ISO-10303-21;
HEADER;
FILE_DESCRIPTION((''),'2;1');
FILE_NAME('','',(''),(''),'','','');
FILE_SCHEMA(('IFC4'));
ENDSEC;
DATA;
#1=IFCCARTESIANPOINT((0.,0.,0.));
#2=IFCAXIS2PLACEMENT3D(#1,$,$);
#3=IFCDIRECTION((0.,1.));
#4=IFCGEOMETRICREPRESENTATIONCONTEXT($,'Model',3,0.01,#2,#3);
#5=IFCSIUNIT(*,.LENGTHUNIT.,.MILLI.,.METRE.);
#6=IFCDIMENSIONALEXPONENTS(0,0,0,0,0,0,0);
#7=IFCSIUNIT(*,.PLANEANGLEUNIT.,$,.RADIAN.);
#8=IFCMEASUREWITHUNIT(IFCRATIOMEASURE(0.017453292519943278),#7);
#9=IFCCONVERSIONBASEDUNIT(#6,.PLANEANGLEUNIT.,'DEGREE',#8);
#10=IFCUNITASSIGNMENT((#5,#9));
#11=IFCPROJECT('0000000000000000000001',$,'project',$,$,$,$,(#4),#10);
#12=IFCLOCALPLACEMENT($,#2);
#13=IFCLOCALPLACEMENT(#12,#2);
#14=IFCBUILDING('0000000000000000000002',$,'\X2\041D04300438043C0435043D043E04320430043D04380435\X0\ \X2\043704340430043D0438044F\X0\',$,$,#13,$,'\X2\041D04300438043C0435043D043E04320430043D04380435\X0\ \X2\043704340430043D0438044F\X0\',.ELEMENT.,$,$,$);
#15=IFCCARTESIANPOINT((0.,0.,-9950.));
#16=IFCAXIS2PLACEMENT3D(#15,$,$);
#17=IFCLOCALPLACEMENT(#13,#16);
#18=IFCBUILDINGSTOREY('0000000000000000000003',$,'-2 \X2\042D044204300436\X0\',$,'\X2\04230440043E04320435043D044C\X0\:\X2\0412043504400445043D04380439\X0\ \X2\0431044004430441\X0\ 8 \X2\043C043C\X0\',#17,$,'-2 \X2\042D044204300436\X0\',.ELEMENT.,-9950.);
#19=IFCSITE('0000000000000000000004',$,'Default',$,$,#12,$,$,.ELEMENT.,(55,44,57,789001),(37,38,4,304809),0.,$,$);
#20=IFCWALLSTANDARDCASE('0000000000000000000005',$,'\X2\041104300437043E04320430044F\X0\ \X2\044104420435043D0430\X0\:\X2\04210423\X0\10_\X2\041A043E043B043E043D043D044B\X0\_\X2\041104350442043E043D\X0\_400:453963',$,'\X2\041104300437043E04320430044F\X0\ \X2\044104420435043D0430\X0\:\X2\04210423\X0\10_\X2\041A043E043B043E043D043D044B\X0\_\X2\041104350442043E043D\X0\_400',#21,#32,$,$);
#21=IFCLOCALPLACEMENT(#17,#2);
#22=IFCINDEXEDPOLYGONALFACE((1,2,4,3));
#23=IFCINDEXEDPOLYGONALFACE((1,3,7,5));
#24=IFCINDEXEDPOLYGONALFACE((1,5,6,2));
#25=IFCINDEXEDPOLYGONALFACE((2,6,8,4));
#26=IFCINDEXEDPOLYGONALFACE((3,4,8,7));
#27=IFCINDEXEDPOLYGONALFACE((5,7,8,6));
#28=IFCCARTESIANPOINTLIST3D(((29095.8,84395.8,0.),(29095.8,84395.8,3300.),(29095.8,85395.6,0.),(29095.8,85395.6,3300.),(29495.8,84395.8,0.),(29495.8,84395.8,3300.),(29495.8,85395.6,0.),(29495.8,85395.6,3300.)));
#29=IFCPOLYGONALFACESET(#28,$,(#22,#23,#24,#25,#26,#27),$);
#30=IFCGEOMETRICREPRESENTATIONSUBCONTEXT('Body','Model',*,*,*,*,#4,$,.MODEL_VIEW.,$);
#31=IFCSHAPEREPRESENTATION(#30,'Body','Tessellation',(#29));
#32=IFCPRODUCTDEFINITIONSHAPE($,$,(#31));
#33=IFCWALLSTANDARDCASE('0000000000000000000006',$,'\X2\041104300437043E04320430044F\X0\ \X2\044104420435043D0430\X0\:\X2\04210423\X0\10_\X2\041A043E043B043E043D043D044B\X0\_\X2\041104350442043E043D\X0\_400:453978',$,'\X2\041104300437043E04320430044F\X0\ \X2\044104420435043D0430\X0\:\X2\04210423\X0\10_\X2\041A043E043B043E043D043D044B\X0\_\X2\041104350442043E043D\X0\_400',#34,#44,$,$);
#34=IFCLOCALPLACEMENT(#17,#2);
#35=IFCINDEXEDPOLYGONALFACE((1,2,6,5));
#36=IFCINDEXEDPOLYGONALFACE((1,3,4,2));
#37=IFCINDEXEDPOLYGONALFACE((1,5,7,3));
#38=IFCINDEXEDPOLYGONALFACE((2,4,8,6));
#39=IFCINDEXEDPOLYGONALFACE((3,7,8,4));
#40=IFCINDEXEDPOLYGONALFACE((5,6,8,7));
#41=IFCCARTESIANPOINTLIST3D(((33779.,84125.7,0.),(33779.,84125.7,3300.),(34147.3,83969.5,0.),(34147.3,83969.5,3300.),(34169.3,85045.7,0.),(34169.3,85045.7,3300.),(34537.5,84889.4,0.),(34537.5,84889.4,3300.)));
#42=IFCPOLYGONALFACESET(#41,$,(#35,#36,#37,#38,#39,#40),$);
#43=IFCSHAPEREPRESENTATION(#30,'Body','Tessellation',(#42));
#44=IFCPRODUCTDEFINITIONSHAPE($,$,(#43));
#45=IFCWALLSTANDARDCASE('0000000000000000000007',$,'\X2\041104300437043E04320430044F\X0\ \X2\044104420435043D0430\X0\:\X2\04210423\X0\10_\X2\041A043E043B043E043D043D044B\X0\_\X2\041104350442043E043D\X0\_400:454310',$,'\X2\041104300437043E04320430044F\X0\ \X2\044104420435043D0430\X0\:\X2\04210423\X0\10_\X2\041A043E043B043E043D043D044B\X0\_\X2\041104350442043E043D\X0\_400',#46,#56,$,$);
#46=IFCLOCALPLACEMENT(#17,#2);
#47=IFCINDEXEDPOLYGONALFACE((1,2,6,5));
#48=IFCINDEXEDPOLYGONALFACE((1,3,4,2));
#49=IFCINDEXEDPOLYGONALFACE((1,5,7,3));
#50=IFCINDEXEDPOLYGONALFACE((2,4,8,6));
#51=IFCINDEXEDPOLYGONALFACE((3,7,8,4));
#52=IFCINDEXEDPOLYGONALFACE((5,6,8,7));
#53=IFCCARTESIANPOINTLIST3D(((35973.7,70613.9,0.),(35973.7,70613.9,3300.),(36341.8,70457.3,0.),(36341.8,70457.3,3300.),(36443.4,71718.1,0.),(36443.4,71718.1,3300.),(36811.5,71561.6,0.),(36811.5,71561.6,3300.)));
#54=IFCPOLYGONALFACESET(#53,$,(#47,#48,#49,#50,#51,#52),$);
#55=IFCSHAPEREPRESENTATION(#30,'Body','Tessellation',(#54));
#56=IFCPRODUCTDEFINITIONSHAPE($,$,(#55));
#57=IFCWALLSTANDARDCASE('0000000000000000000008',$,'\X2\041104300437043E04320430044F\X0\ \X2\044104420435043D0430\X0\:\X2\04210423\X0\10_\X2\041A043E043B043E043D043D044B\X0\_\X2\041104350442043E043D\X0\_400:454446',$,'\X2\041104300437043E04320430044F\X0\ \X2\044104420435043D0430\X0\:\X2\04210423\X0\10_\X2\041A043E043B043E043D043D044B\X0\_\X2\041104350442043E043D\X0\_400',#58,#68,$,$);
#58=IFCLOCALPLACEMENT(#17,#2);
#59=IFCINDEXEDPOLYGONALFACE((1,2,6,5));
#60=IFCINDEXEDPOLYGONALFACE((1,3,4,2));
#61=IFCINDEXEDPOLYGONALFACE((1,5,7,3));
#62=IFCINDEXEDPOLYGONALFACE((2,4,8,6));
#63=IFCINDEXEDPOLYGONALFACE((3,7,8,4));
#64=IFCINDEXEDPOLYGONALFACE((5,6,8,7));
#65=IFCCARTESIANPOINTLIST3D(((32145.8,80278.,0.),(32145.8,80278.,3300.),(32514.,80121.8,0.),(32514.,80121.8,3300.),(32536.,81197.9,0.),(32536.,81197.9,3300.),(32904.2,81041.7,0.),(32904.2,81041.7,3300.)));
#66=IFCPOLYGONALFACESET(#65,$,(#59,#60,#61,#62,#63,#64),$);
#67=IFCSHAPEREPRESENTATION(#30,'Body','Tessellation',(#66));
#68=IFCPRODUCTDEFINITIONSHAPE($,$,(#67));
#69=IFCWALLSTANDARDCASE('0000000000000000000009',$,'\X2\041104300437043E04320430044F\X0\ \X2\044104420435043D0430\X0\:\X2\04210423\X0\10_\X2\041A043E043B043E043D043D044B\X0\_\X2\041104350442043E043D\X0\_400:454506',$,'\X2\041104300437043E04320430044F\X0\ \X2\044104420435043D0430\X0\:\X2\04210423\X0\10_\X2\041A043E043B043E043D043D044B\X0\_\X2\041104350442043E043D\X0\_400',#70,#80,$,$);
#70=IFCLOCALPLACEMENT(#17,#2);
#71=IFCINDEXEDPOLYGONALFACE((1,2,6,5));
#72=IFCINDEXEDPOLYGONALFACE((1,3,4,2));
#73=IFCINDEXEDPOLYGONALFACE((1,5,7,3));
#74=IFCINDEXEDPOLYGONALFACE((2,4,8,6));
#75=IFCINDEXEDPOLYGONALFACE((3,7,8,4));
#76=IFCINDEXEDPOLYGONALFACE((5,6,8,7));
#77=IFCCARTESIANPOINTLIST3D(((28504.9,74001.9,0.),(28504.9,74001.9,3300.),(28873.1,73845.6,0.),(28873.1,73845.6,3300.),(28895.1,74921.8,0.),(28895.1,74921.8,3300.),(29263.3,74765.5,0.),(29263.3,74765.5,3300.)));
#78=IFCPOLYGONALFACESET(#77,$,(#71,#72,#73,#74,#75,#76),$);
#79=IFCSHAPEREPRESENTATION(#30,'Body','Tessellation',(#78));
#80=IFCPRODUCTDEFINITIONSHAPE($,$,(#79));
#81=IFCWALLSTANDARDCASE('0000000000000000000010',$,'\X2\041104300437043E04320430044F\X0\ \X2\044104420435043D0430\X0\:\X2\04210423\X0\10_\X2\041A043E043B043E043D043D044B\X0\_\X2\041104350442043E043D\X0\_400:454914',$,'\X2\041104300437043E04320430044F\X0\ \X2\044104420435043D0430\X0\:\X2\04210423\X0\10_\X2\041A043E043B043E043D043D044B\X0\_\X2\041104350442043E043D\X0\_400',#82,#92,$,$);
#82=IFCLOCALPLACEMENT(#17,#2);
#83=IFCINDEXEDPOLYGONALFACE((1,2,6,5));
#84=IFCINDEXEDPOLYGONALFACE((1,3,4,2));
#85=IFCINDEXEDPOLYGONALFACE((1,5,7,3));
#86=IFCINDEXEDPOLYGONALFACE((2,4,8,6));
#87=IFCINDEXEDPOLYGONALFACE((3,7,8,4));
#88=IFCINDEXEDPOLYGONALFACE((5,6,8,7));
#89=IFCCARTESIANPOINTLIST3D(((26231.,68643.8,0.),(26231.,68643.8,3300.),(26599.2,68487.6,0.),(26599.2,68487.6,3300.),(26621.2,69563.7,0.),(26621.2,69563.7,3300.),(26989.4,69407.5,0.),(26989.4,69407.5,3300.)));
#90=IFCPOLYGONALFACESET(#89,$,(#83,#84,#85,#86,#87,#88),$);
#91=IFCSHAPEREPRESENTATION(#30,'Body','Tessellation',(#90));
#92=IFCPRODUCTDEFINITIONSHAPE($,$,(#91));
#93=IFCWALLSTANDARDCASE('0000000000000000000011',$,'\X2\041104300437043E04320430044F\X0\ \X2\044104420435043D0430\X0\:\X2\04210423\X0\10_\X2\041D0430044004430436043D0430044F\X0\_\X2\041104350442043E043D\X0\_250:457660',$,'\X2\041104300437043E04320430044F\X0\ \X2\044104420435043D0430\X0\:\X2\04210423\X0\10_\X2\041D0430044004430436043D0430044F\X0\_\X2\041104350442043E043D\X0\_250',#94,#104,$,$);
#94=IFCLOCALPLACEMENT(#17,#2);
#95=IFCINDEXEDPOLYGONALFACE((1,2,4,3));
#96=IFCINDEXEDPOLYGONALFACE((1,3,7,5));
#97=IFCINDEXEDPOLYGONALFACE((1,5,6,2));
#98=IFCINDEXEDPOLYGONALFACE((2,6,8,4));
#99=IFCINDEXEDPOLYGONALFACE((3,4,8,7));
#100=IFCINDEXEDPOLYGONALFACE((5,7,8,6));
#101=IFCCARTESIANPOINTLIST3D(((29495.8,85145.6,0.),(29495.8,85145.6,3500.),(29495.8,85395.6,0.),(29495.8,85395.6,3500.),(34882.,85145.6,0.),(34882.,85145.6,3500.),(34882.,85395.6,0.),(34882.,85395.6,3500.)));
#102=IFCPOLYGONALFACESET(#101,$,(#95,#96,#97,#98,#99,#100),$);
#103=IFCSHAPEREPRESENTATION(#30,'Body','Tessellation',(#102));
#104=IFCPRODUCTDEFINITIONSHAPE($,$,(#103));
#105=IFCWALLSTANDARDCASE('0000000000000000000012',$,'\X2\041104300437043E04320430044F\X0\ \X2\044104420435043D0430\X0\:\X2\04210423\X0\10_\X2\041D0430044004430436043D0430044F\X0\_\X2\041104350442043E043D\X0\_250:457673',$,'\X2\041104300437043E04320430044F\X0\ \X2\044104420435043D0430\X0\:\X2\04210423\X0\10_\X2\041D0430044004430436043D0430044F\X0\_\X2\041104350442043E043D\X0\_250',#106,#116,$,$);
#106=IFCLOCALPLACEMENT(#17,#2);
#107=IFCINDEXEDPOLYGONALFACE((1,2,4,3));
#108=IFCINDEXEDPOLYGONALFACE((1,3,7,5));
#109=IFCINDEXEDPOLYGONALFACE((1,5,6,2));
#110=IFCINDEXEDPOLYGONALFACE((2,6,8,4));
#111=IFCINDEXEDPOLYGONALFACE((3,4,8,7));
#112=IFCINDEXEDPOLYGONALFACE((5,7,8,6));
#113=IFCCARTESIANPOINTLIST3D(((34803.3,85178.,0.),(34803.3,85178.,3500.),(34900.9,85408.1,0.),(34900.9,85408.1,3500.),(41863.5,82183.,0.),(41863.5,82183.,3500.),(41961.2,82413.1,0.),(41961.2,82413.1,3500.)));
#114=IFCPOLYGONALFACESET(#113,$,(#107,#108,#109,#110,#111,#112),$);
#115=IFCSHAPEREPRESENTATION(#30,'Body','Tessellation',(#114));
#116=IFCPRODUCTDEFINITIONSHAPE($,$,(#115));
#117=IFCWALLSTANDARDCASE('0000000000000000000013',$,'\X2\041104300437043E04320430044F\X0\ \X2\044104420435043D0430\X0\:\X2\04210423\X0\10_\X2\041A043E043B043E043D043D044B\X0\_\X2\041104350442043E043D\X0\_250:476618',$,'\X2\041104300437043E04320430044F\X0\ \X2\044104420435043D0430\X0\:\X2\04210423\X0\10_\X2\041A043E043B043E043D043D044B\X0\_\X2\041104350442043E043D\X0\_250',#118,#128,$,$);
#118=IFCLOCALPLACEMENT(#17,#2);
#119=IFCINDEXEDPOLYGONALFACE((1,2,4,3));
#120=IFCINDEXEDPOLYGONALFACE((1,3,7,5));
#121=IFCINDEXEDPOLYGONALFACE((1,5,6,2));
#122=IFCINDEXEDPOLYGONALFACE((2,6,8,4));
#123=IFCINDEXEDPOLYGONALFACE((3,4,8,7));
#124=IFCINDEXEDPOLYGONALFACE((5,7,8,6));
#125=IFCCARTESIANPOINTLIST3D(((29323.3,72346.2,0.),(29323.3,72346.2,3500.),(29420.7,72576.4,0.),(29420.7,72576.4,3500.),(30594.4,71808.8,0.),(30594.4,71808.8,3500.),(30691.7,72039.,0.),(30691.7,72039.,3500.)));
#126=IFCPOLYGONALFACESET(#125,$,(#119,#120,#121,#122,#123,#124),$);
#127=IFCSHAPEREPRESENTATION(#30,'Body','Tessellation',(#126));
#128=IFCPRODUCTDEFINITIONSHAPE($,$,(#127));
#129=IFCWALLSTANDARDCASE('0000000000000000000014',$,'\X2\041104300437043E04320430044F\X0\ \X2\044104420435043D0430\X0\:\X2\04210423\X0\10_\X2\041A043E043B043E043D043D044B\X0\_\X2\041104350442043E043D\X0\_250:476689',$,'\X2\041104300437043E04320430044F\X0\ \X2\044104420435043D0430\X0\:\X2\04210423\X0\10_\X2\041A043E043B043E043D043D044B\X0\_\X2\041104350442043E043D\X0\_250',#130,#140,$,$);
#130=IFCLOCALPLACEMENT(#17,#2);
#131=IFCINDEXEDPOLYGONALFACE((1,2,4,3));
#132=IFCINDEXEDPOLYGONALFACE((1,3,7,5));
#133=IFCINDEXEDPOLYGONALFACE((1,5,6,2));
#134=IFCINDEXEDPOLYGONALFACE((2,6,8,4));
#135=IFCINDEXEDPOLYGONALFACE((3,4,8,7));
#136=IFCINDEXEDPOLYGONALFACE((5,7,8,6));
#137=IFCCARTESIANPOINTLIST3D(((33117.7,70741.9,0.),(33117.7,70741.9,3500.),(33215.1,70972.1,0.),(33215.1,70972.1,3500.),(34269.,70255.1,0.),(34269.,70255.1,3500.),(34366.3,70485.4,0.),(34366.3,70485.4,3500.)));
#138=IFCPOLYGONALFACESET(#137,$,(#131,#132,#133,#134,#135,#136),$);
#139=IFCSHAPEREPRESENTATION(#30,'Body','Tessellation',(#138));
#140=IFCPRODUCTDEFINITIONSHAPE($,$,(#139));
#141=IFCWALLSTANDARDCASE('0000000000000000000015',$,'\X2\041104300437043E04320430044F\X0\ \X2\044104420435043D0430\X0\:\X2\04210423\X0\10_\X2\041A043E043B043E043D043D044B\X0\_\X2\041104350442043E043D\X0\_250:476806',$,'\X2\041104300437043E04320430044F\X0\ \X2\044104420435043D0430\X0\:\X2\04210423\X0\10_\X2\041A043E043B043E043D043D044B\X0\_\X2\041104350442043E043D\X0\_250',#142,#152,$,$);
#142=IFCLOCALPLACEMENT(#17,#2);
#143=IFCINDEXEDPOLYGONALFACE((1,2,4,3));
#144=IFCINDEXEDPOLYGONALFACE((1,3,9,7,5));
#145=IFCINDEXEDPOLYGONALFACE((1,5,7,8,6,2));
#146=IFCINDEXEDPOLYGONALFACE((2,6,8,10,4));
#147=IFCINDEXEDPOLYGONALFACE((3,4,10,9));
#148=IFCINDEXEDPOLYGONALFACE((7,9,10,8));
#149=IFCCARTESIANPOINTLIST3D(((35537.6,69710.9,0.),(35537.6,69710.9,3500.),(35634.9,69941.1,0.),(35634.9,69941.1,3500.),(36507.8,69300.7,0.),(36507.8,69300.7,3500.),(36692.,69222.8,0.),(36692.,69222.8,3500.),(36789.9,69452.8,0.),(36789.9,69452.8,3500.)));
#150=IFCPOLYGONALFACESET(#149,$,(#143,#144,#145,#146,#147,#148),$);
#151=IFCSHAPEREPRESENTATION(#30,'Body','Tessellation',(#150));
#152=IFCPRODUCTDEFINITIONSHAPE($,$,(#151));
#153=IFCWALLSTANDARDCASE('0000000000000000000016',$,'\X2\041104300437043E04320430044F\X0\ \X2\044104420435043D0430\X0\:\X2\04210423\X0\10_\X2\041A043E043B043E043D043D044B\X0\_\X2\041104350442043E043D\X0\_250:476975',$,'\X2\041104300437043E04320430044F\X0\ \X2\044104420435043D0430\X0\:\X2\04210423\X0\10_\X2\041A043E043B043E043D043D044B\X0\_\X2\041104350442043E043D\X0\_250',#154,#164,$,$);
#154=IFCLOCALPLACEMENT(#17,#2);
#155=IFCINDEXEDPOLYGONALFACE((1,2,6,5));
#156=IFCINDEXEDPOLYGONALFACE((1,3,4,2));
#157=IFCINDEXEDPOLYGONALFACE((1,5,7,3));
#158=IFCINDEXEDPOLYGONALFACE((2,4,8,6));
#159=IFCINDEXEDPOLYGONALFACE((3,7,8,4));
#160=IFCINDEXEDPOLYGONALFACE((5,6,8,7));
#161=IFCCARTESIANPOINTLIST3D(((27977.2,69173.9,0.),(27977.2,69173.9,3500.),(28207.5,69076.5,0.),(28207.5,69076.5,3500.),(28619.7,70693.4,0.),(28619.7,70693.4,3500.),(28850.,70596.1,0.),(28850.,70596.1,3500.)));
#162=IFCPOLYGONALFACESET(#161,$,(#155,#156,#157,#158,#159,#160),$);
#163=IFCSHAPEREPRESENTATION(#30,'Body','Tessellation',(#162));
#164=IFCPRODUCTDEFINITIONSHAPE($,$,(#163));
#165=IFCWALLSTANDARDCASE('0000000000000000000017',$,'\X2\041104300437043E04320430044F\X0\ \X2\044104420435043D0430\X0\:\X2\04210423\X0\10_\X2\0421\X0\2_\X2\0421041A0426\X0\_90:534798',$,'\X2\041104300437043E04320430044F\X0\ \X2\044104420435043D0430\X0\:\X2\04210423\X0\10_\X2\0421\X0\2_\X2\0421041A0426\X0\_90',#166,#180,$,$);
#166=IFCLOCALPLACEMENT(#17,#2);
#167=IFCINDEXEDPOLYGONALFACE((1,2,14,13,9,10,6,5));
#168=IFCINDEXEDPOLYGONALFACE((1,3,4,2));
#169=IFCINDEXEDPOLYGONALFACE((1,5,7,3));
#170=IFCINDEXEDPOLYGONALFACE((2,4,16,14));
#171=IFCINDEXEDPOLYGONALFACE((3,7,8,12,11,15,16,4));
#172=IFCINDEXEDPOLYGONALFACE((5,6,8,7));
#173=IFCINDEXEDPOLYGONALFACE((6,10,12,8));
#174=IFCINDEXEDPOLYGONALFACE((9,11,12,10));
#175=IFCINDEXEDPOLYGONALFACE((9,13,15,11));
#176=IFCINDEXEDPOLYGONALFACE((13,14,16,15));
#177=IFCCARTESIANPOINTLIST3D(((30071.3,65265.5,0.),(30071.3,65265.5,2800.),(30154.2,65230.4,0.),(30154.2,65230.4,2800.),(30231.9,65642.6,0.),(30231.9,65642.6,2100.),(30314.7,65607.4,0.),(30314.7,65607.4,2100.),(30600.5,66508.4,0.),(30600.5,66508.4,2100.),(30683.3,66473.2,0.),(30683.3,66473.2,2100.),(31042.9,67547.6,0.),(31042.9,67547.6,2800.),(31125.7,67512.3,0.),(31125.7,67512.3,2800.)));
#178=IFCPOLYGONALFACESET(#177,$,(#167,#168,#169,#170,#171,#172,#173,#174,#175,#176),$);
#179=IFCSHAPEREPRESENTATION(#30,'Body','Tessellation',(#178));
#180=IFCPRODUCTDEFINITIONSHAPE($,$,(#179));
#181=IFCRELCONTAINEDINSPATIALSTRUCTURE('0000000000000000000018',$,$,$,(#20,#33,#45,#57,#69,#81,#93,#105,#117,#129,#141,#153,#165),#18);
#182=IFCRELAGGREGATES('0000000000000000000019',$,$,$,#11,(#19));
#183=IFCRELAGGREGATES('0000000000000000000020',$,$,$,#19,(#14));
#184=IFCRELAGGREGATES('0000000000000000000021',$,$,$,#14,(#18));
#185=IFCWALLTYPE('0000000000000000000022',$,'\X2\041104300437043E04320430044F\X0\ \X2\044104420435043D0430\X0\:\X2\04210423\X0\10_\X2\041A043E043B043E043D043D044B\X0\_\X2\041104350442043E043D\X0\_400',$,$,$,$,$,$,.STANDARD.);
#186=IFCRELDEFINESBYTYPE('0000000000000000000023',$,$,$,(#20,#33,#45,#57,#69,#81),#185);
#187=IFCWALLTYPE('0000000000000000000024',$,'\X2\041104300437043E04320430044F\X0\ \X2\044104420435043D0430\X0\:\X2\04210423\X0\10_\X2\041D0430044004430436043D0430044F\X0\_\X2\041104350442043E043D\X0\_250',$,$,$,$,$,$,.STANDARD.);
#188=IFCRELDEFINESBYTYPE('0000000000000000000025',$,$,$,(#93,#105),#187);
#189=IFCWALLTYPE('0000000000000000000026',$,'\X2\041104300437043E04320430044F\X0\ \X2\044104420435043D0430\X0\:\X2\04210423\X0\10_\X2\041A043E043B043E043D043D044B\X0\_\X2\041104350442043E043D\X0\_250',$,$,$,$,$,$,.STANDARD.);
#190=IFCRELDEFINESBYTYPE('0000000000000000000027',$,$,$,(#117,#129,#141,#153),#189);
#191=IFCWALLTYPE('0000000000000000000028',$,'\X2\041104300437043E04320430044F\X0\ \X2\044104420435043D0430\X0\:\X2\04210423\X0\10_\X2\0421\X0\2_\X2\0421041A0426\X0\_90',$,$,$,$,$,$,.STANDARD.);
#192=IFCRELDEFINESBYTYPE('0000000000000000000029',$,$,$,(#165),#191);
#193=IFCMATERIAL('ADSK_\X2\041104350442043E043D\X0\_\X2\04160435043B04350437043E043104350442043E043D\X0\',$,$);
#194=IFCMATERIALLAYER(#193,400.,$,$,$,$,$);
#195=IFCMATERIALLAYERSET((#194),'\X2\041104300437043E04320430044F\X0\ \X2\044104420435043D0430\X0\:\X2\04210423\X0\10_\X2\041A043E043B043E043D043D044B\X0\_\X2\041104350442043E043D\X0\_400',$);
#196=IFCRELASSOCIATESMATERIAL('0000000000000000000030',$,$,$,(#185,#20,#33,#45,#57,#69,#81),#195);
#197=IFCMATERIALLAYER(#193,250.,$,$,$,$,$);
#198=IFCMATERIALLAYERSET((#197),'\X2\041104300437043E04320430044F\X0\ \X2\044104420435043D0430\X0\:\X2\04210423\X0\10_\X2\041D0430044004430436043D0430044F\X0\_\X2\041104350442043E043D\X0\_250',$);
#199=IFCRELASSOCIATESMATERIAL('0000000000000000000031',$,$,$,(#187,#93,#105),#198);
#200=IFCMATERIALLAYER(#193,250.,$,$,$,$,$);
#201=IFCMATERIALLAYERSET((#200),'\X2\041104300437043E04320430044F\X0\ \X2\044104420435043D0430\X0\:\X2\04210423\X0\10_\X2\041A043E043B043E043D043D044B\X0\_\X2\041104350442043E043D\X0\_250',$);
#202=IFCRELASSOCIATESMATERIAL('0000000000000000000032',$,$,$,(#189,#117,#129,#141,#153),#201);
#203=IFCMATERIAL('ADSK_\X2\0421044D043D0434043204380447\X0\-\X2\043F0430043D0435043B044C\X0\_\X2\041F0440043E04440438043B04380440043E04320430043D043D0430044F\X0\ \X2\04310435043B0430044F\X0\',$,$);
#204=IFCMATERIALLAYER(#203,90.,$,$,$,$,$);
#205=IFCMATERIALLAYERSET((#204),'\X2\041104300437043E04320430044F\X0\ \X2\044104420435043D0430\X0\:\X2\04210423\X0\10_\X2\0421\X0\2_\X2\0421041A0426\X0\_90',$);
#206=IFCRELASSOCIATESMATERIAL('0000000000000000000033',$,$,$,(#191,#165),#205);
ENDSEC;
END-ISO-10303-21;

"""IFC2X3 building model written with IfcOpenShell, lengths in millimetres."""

from ifc_helpers import new_model, entity, si_unit, converted_unit, direction, frame, frame_2d, origin, place, context, subcontext, project, spatial, polyline, rectangle, outline, extrude, material, layer, layer_set, layer_usage, type_object, element, save


model = new_model("IFC2X3")

# Units and contexts
model_context = context("Model", 3, precision=0.01, world=origin(), true_north=direction((0.0, 1.0)))
body_context = subcontext(model_context, "Body", "Model", "MODEL_VIEW")
ifc_project = project(units=[si_unit("LENGTHUNIT", "METRE", prefix="MILLI"), converted_unit("PLANEANGLEUNIT", "DEGREE", entity("IfcRatioMeasure", 0.017453292519943278), si_unit("PLANEANGLEUNIT", "RADIAN"), dimensions=[0, 0, 0, 0, 0, 0, 0])], contexts=[model_context])

# Site, building, storey
site_placement = place(None, origin())
site = spatial("IfcSite", under=ifc_project, at=site_placement, Name="Default", CompositionType="ELEMENT", RefLatitude=(55, 44, 57, 789001), RefLongitude=(37, 38, 4, 304809), RefElevation=0.0)
building_placement = place(site_placement, origin())
building = spatial("IfcBuilding", under=site, at=building_placement, Name="Наименование здания", LongName="Наименование здания", CompositionType="ELEMENT")
storey_placement = place(building_placement, frame((0.0, 0.0, -9950.0)))
storey = spatial("IfcBuildingStorey", under=building, at=storey_placement, Name="-2 Этаж", ObjectType="Уровень:Верхний брус 8 мм", LongName="-2 Этаж", CompositionType="ELEMENT", Elevation=-9950.0)

# Walls
ifc_material_1 = material(Name="ADSK_Бетон_Железобетон")
ifc_layer_1 = layer(ifc_material_1, 400.0)
ifc_layer_set_1 = layer_set([ifc_layer_1], Name="Базовая стена:СУ10_Колонны_Бетон_400")
ifc_layer_usage_1 = layer_usage(ifc_layer_set_1, "AXIS2", "NEGATIVE", 200.0)
wall_type_1 = type_object("IfcWallType", Name="Базовая стена:СУ10_Колонны_Бетон_400", PredefinedType="STANDARD", material=ifc_layer_set_1)
wall_1_placement = place(storey_placement, frame((29295.8, 85395.6, 0.0), z_axis=(0.0, 0.0, 1.0), x_axis=(0.0, -1.0, 0.0)))
element("IfcWallStandardCase", 1, at=wall_1_placement, inside=storey, type_object=wall_type_1, material=ifc_layer_usage_1, Name="Базовая стена:СУ10_Колонны_Бетон_400:453963", ObjectType="Базовая стена:СУ10_Колонны_Бетон_400", context=body_context, shape_type="SweptSolid", body=[
    extrude(rectangle(XDim=999.8, YDim=400.0, at=frame_2d((499.9, 0.0), x_axis=(-1.0, 0.0))), origin(), (0.0, 0.0, 1.0), 3300.0),
])
wall_2_placement = place(storey_placement, frame((33963.2, 84047.6, 0.0), z_axis=(0.0, 0.0, 1.0), x_axis=(0.390521, 0.920594, 0.0)))
element("IfcWallStandardCase", 2, at=wall_2_placement, inside=storey, type_object=wall_type_1, material=ifc_layer_usage_1, Name="Базовая стена:СУ10_Колонны_Бетон_400:453978", ObjectType="Базовая стена:СУ10_Колонны_Бетон_400", context=body_context, shape_type="SweptSolid", body=[
    extrude(rectangle(XDim=999.2, YDim=400.0, at=frame_2d((499.6, 0.0), x_axis=(-1.0, 0.0))), origin(), (0.0, 0.0, 1.0), 3300.0),
])
wall_3_placement = place(storey_placement, frame((36157.8, 70535.6, 0.0), z_axis=(0.0, 0.0, 1.0), x_axis=(0.391365, 0.920236, 0.0)))
element("IfcWallStandardCase", 3, at=wall_3_placement, inside=storey, type_object=wall_type_1, material=ifc_layer_usage_1, Name="Базовая стена:СУ10_Колонны_Бетон_400:454310", ObjectType="Базовая стена:СУ10_Колонны_Бетон_400", context=body_context, shape_type="SweptSolid", body=[
    extrude(rectangle(XDim=1200.0, YDim=400.0, at=frame_2d((600.0, 0.0), x_axis=(-1.0, 0.0))), origin(), (0.0, 0.0, 1.0), 3300.0),
])
wall_4_placement = place(storey_placement, frame((32329.9, 80199.9, 0.0), z_axis=(0.0, 0.0, 1.0), x_axis=(0.390521, 0.920594, 0.0)))
element("IfcWallStandardCase", 4, at=wall_4_placement, inside=storey, type_object=wall_type_1, material=ifc_layer_usage_1, Name="Базовая стена:СУ10_Колонны_Бетон_400:454446", ObjectType="Базовая стена:СУ10_Колонны_Бетон_400", context=body_context, shape_type="SweptSolid", body=[
    extrude(rectangle(XDim=999.2, YDim=400.0, at=frame_2d((499.6, 0.0), x_axis=(-1.0, 0.0))), origin(), (0.0, 0.0, 1.0), 3300.0),
])
for number, where, z_axis, x_axis, name in (
    (5, (28689.0, 73923.7, 0.0), (0.0, 0.0, 1.0), (0.390521, 0.920594, 0.0), "Базовая стена:СУ10_Колонны_Бетон_400:454506"),
    (6, (26415.1, 68565.7, 0.0), (0.0, 0.0, 1.0), (0.390521, 0.920594, 0.0), "Базовая стена:СУ10_Колонны_Бетон_400:454914"),
):
    element("IfcWallStandardCase", number, at=place(storey_placement, frame(where, z_axis=z_axis, x_axis=x_axis)), inside=storey, type_object=wall_type_1, material=ifc_layer_usage_1, Name=name, ObjectType="Базовая стена:СУ10_Колонны_Бетон_400", context=body_context, shape_type="SweptSolid", body=[
        extrude(rectangle(XDim=999.2, YDim=400.0, at=frame_2d((499.6, 0.0), x_axis=(-1.0, 0.0))), origin(), (0.0, 0.0, 1.0), 3300.0),
    ])
ifc_layer_2 = layer(ifc_material_1, 250.0)
ifc_layer_set_2 = layer_set([ifc_layer_2], Name="Базовая стена:СУ10_Наружная_Бетон_250")
ifc_layer_usage_2 = layer_usage(ifc_layer_set_2, "AXIS2", "NEGATIVE", 125.0)
wall_type_2 = type_object("IfcWallType", Name="Базовая стена:СУ10_Наружная_Бетон_250", PredefinedType="STANDARD", material=ifc_layer_set_2)
wall_5_placement = place(storey_placement, frame((29495.8, 85270.6, 0.0)))
element("IfcWallStandardCase", 7, at=wall_5_placement, inside=storey, type_object=wall_type_2, material=ifc_layer_usage_2, Name="Базовая стена:СУ10_Наружная_Бетон_250:457660", ObjectType="Базовая стена:СУ10_Наружная_Бетон_250", context=body_context, shape_type="SweptSolid", body=[
    extrude(rectangle(XDim=5386.2, YDim=250.0, at=frame_2d((2693.1, 0.0), x_axis=(-1.0, 0.0))), origin(), (0.0, 0.0, 1.0), 3500.0),
])
wall_6_placement = place(storey_placement, frame((34852.1, 85293.1, 0.0), z_axis=(0.0, 0.0, 1.0), x_axis=(0.920594, -0.390521, 0.0)))
element("IfcWallStandardCase", 8, at=wall_6_placement, inside=storey, type_object=wall_type_2, material=ifc_layer_usage_2, Name="Базовая стена:СУ10_Наружная_Бетон_250:457673", ObjectType="Базовая стена:СУ10_Наружная_Бетон_250", context=body_context, shape_type="SweptSolid", body=[
    extrude(rectangle(XDim=7669.3, YDim=250.0, at=frame_2d((3834.6, 0.0), x_axis=(-1.0, 0.0))), origin(), (0.0, 0.0, 1.0), 3500.0),
])
ifc_layer_3 = layer(ifc_material_1, 250.0)
ifc_layer_set_3 = layer_set([ifc_layer_3], Name="Базовая стена:СУ10_Колонны_Бетон_250")
ifc_layer_usage_3 = layer_usage(ifc_layer_set_3, "AXIS2", "NEGATIVE", 125.0)
wall_type_3 = type_object("IfcWallType", Name="Базовая стена:СУ10_Колонны_Бетон_250", PredefinedType="STANDARD", material=ifc_layer_set_3)
wall_7_placement = place(storey_placement, frame((30643.0, 71923.9, 0.0), z_axis=(0.0, 0.0, 1.0), x_axis=(-0.921057, 0.389429, 0.0)))
element("IfcWallStandardCase", 9, at=wall_7_placement, inside=storey, type_object=wall_type_3, material=ifc_layer_usage_3, Name="Базовая стена:СУ10_Колонны_Бетон_250:476618", ObjectType="Базовая стена:СУ10_Колонны_Бетон_250", context=body_context, shape_type="SweptSolid", body=[
    extrude(rectangle(XDim=1380.0, YDim=250.0, at=frame_2d((690.0, 0.0), x_axis=(-1.0, 0.0))), origin(), (0.0, 0.0, 1.0), 3500.0),
])
wall_8_placement = place(storey_placement, frame((34317.6, 70370.3, 0.0), z_axis=(0.0, 0.0, 1.0), x_axis=(-0.921062, 0.389417, 0.0)))
element("IfcWallStandardCase", 10, at=wall_8_placement, inside=storey, type_object=wall_type_3, material=ifc_layer_usage_3, Name="Базовая стена:СУ10_Колонны_Бетон_250:476689", ObjectType="Базовая стена:СУ10_Колонны_Бетон_250", context=body_context, shape_type="SweptSolid", body=[
    extrude(rectangle(XDim=1249.9, YDim=250.0, at=frame_2d((625.0, 0.0), x_axis=(-1.0, 0.0))), origin(), (0.0, 0.0, 1.0), 3500.0),
])
wall_9_placement = place(storey_placement, frame((36741.3, 69337.7, 0.0), z_axis=(0.0, 0.0, 1.0), x_axis=(-0.921062, 0.389417, 0.0)))
element("IfcWallStandardCase", 11, at=wall_9_placement, inside=storey, type_object=wall_type_3, material=ifc_layer_usage_3, Name="Базовая стена:СУ10_Колонны_Бетон_250:476806", ObjectType="Базовая стена:СУ10_Колонны_Бетон_250", context=body_context, shape_type="SweptSolid", body=[
    extrude(outline(polyline([(1254.0, -125.0), (1254.0, 125.0), (200.6, 125.0), (0.6, 125.0), (0.0, -125.0), (1254.0, -125.0)])), origin(), (0.0, 0.0, 1.0), 3500.0),
])
wall_10_placement = place(storey_placement, frame((28092.4, 69125.2, 0.0), z_axis=(0.0, 0.0, 1.0), x_axis=(0.389417, 0.921062, 0.0)))
element("IfcWallStandardCase", 12, at=wall_10_placement, inside=storey, type_object=wall_type_3, material=ifc_layer_usage_3, Name="Базовая стена:СУ10_Колонны_Бетон_250:476975", ObjectType="Базовая стена:СУ10_Колонны_Бетон_250", context=body_context, shape_type="SweptSolid", body=[
    extrude(rectangle(XDim=1649.8, YDim=250.0, at=frame_2d((824.9, 0.0), x_axis=(-1.0, 0.0))), origin(), (0.0, 0.0, 1.0), 3500.0),
])

# Wall, opening
ifc_material_2 = material(Name="ADSK_Сэндвич-панель_Профилированная белая")
ifc_layer_4 = layer(ifc_material_2, 90.0)
ifc_layer_set_4 = layer_set([ifc_layer_4], Name="Базовая стена:СУ10_С2_СКЦ_90")
ifc_layer_usage_4 = layer_usage(ifc_layer_set_4, "AXIS2", "NEGATIVE", 45.0)
wall_type_4 = type_object("IfcWallType", Name="Базовая стена:СУ10_С2_СКЦ_90", PredefinedType="STANDARD", material=ifc_layer_set_4)
wall_11_placement = place(storey_placement, frame((31084.3, 67529.9, 0.0), z_axis=(0.0, 0.0, 1.0), x_axis=(-0.391735, -0.920078, 0.0)))
wall_11 = element("IfcWallStandardCase", 13, at=wall_11_placement, inside=storey, type_object=wall_type_4, material=ifc_layer_usage_4, Name="Базовая стена:СУ10_С2_СКЦ_90:534798", ObjectType="Базовая стена:СУ10_С2_СКЦ_90", context=body_context, shape_type="SweptSolid", body=[
    extrude(outline(polyline([(0.0, -45.0), (2480.3, -45.0), (2480.1, 45.0), (0.0, 45.0), (0.0, -45.0)])), origin(), (0.0, 0.0, 1.0), 2800.0),
])
opening_1_placement = place(wall_11_placement, origin())
element("IfcOpeningElement", 14, at=opening_1_placement, cuts=wall_11, ObjectType="Opening", context=body_context, shape_type="SweptSolid", body=[
    extrude(rectangle(XDim=2100.0, YDim=941.0, at=frame_2d((0.0, 0.0), x_axis=(1.0, 0.0))), frame((1599.9, -45.0, 1050.0), z_axis=(0.0, 1.0, 0.0), x_axis=(0.0, 0.0, -1.0)), (0.0, 0.0, 1.0), 90.0),
])

save(model, "model.ifc")
